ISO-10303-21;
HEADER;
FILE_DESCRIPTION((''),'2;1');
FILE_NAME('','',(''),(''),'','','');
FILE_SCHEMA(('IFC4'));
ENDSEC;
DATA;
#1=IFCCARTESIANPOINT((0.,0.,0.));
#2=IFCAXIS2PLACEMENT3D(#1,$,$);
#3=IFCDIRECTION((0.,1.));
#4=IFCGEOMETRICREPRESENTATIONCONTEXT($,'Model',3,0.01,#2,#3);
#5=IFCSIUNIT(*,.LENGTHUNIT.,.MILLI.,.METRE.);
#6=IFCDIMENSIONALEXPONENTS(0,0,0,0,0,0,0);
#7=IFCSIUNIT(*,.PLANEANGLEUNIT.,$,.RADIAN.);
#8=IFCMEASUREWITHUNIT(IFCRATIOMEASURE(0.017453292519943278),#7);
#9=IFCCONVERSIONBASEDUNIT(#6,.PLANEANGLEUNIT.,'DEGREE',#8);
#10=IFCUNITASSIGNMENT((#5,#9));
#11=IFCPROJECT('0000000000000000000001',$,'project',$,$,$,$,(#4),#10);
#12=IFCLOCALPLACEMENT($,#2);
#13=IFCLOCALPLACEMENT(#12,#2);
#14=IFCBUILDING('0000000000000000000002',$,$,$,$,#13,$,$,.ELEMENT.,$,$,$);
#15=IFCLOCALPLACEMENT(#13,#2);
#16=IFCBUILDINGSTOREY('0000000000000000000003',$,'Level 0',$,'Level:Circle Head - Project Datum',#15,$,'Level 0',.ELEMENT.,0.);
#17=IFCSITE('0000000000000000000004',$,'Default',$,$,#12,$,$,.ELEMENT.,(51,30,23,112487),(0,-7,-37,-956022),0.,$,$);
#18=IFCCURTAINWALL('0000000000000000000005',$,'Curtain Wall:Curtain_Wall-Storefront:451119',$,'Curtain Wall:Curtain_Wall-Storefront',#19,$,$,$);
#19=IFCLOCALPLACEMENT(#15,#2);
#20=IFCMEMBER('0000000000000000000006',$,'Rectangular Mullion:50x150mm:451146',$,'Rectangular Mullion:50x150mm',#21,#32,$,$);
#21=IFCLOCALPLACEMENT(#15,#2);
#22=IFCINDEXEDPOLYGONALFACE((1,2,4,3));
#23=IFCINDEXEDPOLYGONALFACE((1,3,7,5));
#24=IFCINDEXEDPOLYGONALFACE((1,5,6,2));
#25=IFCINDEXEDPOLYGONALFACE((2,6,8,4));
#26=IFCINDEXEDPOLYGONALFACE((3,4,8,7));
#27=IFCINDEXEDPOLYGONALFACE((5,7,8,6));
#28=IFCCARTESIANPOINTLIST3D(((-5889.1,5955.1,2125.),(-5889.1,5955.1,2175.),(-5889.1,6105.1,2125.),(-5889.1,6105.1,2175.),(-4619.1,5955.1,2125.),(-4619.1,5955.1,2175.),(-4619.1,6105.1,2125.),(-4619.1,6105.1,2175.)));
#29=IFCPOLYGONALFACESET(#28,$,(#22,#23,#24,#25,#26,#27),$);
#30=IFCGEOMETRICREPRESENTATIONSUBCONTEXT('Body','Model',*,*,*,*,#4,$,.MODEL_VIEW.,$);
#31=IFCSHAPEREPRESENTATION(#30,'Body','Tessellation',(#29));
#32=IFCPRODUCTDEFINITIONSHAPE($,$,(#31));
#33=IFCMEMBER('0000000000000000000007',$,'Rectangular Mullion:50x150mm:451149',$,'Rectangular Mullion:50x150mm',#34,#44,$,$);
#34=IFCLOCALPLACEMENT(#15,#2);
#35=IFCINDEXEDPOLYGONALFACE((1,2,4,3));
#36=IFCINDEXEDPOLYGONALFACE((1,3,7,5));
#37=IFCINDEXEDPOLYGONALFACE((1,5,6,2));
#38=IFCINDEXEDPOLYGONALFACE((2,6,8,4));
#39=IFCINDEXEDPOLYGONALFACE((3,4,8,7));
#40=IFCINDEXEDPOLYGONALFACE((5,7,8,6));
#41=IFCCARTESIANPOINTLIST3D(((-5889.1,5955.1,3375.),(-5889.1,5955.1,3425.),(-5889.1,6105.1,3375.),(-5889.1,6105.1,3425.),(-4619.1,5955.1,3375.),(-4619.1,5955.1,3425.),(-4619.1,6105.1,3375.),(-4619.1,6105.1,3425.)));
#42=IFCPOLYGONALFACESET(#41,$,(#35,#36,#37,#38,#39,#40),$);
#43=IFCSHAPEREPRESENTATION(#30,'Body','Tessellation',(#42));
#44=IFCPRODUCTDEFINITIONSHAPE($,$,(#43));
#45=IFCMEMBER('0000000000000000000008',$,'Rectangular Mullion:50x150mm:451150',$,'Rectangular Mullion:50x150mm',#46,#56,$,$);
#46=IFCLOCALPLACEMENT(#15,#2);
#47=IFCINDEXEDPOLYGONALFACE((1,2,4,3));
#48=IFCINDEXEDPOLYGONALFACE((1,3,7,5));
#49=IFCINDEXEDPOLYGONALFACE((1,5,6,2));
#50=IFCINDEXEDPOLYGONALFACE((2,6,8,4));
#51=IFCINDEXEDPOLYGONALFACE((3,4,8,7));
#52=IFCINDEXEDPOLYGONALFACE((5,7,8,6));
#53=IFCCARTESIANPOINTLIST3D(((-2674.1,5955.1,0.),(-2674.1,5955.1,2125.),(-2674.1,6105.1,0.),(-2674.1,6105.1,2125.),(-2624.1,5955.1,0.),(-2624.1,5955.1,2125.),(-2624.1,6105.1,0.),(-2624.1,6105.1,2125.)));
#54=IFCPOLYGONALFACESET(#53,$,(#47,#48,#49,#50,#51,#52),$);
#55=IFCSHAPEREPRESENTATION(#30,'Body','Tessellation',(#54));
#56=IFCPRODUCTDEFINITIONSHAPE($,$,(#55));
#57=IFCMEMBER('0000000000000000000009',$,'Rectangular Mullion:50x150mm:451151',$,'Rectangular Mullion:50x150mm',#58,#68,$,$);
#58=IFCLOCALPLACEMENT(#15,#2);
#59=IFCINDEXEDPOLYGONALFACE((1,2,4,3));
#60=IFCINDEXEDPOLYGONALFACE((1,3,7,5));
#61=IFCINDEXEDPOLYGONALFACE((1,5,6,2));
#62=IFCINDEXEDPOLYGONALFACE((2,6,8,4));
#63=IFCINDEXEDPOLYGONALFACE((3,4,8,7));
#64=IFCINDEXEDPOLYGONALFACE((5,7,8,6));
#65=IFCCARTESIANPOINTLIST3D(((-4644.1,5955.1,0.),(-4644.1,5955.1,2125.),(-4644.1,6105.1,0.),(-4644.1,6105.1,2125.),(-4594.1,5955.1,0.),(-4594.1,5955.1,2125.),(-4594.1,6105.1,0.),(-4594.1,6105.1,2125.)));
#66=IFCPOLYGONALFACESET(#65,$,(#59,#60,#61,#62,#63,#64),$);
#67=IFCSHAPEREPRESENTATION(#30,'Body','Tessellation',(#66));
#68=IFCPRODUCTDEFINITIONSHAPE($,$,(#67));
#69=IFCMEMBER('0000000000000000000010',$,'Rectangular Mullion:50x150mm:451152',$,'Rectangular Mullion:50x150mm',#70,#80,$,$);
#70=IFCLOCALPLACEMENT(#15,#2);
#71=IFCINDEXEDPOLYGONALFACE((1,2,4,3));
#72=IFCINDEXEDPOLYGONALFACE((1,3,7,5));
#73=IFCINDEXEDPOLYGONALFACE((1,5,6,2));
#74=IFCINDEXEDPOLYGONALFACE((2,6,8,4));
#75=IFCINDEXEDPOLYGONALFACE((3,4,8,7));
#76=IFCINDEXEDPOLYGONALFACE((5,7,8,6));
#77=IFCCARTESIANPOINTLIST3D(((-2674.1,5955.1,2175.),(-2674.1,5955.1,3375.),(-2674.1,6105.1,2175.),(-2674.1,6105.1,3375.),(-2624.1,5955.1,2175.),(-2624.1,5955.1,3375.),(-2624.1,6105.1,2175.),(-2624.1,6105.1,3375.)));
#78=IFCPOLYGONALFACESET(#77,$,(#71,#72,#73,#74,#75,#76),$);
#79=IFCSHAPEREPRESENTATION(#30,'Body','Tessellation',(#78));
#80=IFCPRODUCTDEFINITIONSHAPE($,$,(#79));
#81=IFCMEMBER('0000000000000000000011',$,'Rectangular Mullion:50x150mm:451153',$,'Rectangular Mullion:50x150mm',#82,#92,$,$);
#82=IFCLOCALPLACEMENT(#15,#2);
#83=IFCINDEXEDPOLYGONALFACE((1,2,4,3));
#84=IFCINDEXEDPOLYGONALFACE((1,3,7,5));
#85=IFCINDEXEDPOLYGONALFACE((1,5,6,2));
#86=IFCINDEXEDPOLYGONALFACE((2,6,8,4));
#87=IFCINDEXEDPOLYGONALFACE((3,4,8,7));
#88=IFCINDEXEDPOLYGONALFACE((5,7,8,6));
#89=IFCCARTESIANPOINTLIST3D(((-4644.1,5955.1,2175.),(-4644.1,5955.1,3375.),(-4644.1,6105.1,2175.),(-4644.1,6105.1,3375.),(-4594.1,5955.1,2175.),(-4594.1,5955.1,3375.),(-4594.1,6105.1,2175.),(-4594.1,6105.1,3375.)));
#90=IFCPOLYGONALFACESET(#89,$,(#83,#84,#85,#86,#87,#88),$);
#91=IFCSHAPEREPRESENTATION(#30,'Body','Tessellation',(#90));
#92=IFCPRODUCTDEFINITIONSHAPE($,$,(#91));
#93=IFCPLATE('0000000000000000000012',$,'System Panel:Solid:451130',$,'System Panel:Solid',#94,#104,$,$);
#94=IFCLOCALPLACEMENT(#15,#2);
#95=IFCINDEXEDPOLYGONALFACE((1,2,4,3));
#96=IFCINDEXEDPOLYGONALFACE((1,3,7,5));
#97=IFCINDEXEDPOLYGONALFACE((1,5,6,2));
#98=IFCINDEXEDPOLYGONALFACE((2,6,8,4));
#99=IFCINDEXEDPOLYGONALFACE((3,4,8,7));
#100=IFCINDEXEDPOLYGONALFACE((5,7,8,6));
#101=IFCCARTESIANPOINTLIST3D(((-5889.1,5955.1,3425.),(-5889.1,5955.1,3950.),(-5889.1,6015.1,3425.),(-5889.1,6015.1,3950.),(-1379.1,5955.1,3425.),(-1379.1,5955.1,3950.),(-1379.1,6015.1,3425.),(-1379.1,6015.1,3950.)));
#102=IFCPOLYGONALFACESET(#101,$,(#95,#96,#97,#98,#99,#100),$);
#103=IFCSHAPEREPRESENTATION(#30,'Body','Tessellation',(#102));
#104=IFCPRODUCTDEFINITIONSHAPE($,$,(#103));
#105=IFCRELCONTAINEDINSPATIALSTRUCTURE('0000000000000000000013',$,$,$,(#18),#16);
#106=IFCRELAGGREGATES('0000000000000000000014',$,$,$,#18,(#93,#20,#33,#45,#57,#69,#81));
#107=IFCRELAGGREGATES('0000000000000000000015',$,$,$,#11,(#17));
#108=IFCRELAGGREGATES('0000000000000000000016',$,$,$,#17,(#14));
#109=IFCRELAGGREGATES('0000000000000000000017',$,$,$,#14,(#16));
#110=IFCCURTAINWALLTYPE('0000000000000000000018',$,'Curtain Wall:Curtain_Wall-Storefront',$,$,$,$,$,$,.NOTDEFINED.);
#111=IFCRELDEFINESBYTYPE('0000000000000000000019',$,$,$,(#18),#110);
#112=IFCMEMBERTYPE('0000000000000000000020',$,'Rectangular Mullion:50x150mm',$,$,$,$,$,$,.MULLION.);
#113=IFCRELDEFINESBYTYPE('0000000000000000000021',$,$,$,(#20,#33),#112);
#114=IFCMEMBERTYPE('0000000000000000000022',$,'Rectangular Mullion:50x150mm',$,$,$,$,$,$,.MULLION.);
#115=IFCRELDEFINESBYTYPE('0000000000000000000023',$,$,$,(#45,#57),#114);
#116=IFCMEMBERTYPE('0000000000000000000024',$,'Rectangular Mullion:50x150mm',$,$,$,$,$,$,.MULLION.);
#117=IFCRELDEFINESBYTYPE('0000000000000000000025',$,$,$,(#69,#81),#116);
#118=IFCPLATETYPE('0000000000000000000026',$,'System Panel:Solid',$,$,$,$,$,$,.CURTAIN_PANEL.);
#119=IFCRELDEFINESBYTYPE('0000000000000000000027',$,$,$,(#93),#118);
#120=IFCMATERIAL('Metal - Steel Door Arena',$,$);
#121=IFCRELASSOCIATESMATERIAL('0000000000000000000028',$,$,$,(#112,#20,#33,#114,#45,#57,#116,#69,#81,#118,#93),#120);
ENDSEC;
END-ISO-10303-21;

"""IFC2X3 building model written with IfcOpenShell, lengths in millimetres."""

from ifc_helpers import new_model, entity, si_unit, converted_unit, direction, frame, frame_2d, origin, origin_2d_with_axis, place, context, subcontext, project, spatial, rectangle, extrude, source, transform, mapped, material, type_object, type_shapes, element, aggregate, save


model = new_model("IFC2X3")

# Units and contexts
model_context = context("Model", 3, precision=0.01, world=origin(), true_north=direction((0.0, 1.0)))
body_context = subcontext(model_context, "Body", "Model", "MODEL_VIEW")
ifc_project = project(units=[si_unit("LENGTHUNIT", "METRE", prefix="MILLI"), converted_unit("PLANEANGLEUNIT", "DEGREE", entity("IfcRatioMeasure", 0.017453292519943278), si_unit("PLANEANGLEUNIT", "RADIAN"), dimensions=[0, 0, 0, 0, 0, 0, 0])], contexts=[model_context])

# Site, building, storey
site_placement = place(None, origin())
site = spatial("IfcSite", under=ifc_project, at=site_placement, Name="Default", CompositionType="ELEMENT", RefLatitude=(51, 30, 23, 112487), RefLongitude=(0, -7, -37, -956022), RefElevation=0.0)
building_placement = place(site_placement, origin())
building = spatial("IfcBuilding", under=site, at=building_placement, CompositionType="ELEMENT")
storey_placement = place(building_placement, origin())
storey = spatial("IfcBuildingStorey", under=building, at=storey_placement, Name="Level 0", ObjectType="Level:Circle Head - Project Datum", LongName="Level 0", CompositionType="ELEMENT", Elevation=0.0)

# Curtain wall
curtain_wall_type = type_object("IfcCurtainWallType", Name="Curtain Wall:Curtain_Wall-Storefront", PredefinedType="NOTDEFINED")
curtain_wall_1_placement = place(storey_placement, origin())
curtain_wall_1 = element("IfcCurtainWall", 1, at=curtain_wall_1_placement, inside=storey, type_object=curtain_wall_type, Name="Curtain Wall:Curtain_Wall-Storefront:451119", ObjectType="Curtain Wall:Curtain_Wall-Storefront")
ifc_material_1 = material(Name="Metal - Steel Door Arena")

# Members
member_type_1 = type_object("IfcMemberType", Name="Rectangular Mullion:50x150mm", PredefinedType="MULLION", material=ifc_material_1)
shared_shape_1 = source(origin(), body_context, "Body", "SweptSolid", [
    extrude(rectangle(XDim=150.0, YDim=50.0, at=origin_2d_with_axis()), frame((0.0, 0.0, -1270.0), z_axis=(0.0, 0.0, 1.0), x_axis=(0.0, -1.0, 0.0)), (0.0, 0.0, 1.0), 1270.0),
])
type_shapes(member_type_1, [shared_shape_1])
member_1_placement = place(curtain_wall_1_placement, frame((-5889.1, 6030.1, 2150.0), z_axis=(-1.0, 0.0, 0.0), x_axis=(0.0, 0.0, 1.0)))
member_1 = element("IfcMember", 2, at=member_1_placement, type_object=member_type_1, material=ifc_material_1, Name="Rectangular Mullion:50x150mm:451146", ObjectType="Rectangular Mullion:50x150mm", context=body_context, shape_type="MappedRepresentation", body=[
    mapped(shared_shape_1, transform((0.0, 0.0, 0.0), scale=1.0)),
])
member_2_placement = place(curtain_wall_1_placement, frame((-5889.1, 6030.1, 3400.0), z_axis=(-1.0, 0.0, 0.0), x_axis=(0.0, 0.0, 1.0)))
member_2 = element("IfcMember", 3, at=member_2_placement, type_object=member_type_1, material=ifc_material_1, Name="Rectangular Mullion:50x150mm:451149", ObjectType="Rectangular Mullion:50x150mm", context=body_context, shape_type="MappedRepresentation", body=[
    mapped(shared_shape_1, transform((0.0, 0.0, 0.0), scale=1.0)),
])
member_type_2 = type_object("IfcMemberType", Name="Rectangular Mullion:50x150mm", PredefinedType="MULLION", material=ifc_material_1)
shared_shape_2 = source(origin(), body_context, "Body", "SweptSolid", [
    extrude(rectangle(XDim=150.0, YDim=50.0, at=origin_2d_with_axis()), frame((0.0, 0.0, -2125.0), z_axis=(0.0, 0.0, 1.0), x_axis=(0.0, -1.0, 0.0)), (0.0, 0.0, 1.0), 2125.0),
])
type_shapes(member_type_2, [shared_shape_2])
member_3_placement = place(curtain_wall_1_placement, frame((-2649.1, 6030.1, 0.0), z_axis=(0.0, 0.0, -1.0), x_axis=(-1.0, 0.0, 0.0)))
member_3 = element("IfcMember", 4, at=member_3_placement, type_object=member_type_2, material=ifc_material_1, Name="Rectangular Mullion:50x150mm:451150", ObjectType="Rectangular Mullion:50x150mm", context=body_context, shape_type="MappedRepresentation", body=[
    mapped(shared_shape_2, transform((0.0, 0.0, 0.0), scale=1.0)),
])
member_4_placement = place(curtain_wall_1_placement, frame((-4619.1, 6030.1, 0.0), z_axis=(0.0, 0.0, -1.0), x_axis=(-1.0, 0.0, 0.0)))
member_4 = element("IfcMember", 5, at=member_4_placement, type_object=member_type_2, material=ifc_material_1, Name="Rectangular Mullion:50x150mm:451151", ObjectType="Rectangular Mullion:50x150mm", context=body_context, shape_type="MappedRepresentation", body=[
    mapped(shared_shape_2, transform((0.0, 0.0, 0.0), scale=1.0)),
])
member_type_3 = type_object("IfcMemberType", Name="Rectangular Mullion:50x150mm", PredefinedType="MULLION", material=ifc_material_1)
shared_shape_3 = source(origin(), body_context, "Body", "SweptSolid", [
    extrude(rectangle(XDim=150.0, YDim=50.0, at=origin_2d_with_axis()), frame((0.0, 0.0, -1200.0), z_axis=(0.0, 0.0, 1.0), x_axis=(0.0, -1.0, 0.0)), (0.0, 0.0, 1.0), 1200.0),
])
type_shapes(member_type_3, [shared_shape_3])
member_5_placement = place(curtain_wall_1_placement, frame((-2649.1, 6030.1, 2175.0), z_axis=(0.0, 0.0, -1.0), x_axis=(-1.0, 0.0, 0.0)))
member_5 = element("IfcMember", 6, at=member_5_placement, type_object=member_type_3, material=ifc_material_1, Name="Rectangular Mullion:50x150mm:451152", ObjectType="Rectangular Mullion:50x150mm", context=body_context, shape_type="MappedRepresentation", body=[
    mapped(shared_shape_3, transform((0.0, 0.0, 0.0), scale=1.0)),
])
member_6_placement = place(curtain_wall_1_placement, frame((-4619.1, 6030.1, 2175.0), z_axis=(0.0, 0.0, -1.0), x_axis=(-1.0, 0.0, 0.0)))
member_6 = element("IfcMember", 7, at=member_6_placement, type_object=member_type_3, material=ifc_material_1, Name="Rectangular Mullion:50x150mm:451153", ObjectType="Rectangular Mullion:50x150mm", context=body_context, shape_type="MappedRepresentation", body=[
    mapped(shared_shape_3, transform((0.0, 0.0, 0.0), scale=1.0)),
])

# Plate
plate_type_1 = type_object("IfcPlateType", Name="System Panel:Solid", PredefinedType="CURTAIN_PANEL", material=ifc_material_1)
shared_shape_4 = source(origin(), body_context, "Body", "SweptSolid", [
    extrude(rectangle(XDim=525.0, YDim=4510.0, at=frame_2d((0.0, 0.0), x_axis=(1.0, 0.0))), frame((0.0, 15.0, 262.5), z_axis=(0.0, 1.0, 0.0), x_axis=(0.0, 0.0, 1.0)), (0.0, 0.0, 1.0), 60.0),
])
type_shapes(plate_type_1, [shared_shape_4])
plate_1_placement = place(curtain_wall_1_placement, frame((-3634.1, 6030.1, 3425.0), z_axis=(0.0, 0.0, 1.0), x_axis=(-1.0, 0.0, 0.0)))
plate_1 = element("IfcPlate", 8, at=plate_1_placement, type_object=plate_type_1, material=ifc_material_1, Name="System Panel:Solid:451130", ObjectType="System Panel:Solid", context=body_context, shape_type="MappedRepresentation", body=[
    mapped(shared_shape_4, transform((0.0, 0.0, 0.0), scale=1.0)),
])
aggregate(curtain_wall_1, [plate_1, member_1, member_2, member_3, member_4, member_5, member_6])

save(model, "model.ifc")
